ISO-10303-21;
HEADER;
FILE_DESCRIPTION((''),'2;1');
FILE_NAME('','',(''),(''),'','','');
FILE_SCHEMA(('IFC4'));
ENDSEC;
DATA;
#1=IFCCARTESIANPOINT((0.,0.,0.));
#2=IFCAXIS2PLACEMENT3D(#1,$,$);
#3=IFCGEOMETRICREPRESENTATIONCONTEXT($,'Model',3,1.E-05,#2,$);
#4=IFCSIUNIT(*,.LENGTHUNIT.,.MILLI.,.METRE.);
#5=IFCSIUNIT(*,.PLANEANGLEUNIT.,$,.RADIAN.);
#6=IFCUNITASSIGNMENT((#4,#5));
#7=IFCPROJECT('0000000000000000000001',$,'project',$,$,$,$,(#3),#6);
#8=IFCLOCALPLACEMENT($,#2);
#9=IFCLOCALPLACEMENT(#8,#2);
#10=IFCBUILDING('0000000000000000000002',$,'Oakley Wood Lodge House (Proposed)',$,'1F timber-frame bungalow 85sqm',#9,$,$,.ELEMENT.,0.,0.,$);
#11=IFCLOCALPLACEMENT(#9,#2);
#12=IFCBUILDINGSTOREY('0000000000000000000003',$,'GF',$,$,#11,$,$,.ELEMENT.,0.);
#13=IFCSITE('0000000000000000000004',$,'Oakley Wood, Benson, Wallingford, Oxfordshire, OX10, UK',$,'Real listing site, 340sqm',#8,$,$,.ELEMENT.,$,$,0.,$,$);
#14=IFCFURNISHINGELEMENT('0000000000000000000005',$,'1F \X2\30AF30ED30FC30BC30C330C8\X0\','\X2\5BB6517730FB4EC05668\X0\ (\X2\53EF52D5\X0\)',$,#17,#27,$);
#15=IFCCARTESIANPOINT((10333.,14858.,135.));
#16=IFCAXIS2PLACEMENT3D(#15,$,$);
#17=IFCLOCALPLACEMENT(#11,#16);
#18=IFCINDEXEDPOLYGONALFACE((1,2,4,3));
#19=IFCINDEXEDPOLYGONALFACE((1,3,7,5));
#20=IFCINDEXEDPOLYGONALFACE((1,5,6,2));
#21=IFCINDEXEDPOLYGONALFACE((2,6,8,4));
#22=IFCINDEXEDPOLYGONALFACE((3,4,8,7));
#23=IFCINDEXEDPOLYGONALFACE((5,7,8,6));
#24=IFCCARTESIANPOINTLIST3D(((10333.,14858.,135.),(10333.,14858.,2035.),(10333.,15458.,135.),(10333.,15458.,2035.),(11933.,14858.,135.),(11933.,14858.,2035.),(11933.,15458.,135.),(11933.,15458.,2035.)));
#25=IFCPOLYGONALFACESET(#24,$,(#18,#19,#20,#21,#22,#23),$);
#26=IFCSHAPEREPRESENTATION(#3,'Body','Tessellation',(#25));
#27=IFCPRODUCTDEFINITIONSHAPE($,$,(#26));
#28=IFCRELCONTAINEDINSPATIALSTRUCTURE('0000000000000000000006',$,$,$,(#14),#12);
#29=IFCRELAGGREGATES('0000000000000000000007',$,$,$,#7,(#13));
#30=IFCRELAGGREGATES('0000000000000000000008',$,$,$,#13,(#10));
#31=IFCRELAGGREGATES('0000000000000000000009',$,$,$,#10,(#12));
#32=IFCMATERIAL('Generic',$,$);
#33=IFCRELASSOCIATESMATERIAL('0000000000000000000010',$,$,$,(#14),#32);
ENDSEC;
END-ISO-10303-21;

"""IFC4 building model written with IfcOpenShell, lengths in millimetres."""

from ifc_helpers import new_model, si_unit, frame, frame_2d, origin, place, context, project, spatial, rectangle, extrude, material, element, save


model = new_model("IFC4")

# Units and contexts
model_context = context("Model", 3, precision=1e-05, world=origin())
ifc_project = project(units=[si_unit("LENGTHUNIT", "METRE", prefix="MILLI"), si_unit("PLANEANGLEUNIT", "RADIAN")], contexts=[model_context])

# Site, building, storey
site_placement = place(None, origin())
site = spatial("IfcSite", under=ifc_project, at=site_placement, Name="Oakley Wood, Benson, Wallingford, Oxfordshire, OX10, UK", ObjectType="Real listing site, 340sqm", CompositionType="ELEMENT", RefElevation=0.0)
building_placement = place(site_placement, origin())
building = spatial("IfcBuilding", under=site, at=building_placement, Name="Oakley Wood Lodge House (Proposed)", ObjectType="1F timber-frame bungalow 85sqm", CompositionType="ELEMENT", ElevationOfRefHeight=0.0, ElevationOfTerrain=0.0)
storey_placement = place(building_placement, origin())
storey = spatial("IfcBuildingStorey", under=building, at=storey_placement, Name="GF", CompositionType="ELEMENT", Elevation=0.0)

# Shared definitions
ifc_material_1 = material(Name="Generic")

# Furnishing element
furnishing_placement = place(storey_placement, frame((10333.0, 14858.0, 135.0)))
element("IfcFurnishingElement", 1, at=furnishing_placement, inside=storey, material=ifc_material_1, Name="1F クローゼット", Description="家具・什器 (可動)", context=model_context, shape_type="SweptSolid", body=[
    extrude(rectangle(XDim=1600.0, YDim=600.0, at=frame_2d((800.0, 300.0))), frame((10333.0, 14858.0, 135.0)), (0.0, 0.0, 1.0), 1900.0),
])

save(model, "model.ifc")
